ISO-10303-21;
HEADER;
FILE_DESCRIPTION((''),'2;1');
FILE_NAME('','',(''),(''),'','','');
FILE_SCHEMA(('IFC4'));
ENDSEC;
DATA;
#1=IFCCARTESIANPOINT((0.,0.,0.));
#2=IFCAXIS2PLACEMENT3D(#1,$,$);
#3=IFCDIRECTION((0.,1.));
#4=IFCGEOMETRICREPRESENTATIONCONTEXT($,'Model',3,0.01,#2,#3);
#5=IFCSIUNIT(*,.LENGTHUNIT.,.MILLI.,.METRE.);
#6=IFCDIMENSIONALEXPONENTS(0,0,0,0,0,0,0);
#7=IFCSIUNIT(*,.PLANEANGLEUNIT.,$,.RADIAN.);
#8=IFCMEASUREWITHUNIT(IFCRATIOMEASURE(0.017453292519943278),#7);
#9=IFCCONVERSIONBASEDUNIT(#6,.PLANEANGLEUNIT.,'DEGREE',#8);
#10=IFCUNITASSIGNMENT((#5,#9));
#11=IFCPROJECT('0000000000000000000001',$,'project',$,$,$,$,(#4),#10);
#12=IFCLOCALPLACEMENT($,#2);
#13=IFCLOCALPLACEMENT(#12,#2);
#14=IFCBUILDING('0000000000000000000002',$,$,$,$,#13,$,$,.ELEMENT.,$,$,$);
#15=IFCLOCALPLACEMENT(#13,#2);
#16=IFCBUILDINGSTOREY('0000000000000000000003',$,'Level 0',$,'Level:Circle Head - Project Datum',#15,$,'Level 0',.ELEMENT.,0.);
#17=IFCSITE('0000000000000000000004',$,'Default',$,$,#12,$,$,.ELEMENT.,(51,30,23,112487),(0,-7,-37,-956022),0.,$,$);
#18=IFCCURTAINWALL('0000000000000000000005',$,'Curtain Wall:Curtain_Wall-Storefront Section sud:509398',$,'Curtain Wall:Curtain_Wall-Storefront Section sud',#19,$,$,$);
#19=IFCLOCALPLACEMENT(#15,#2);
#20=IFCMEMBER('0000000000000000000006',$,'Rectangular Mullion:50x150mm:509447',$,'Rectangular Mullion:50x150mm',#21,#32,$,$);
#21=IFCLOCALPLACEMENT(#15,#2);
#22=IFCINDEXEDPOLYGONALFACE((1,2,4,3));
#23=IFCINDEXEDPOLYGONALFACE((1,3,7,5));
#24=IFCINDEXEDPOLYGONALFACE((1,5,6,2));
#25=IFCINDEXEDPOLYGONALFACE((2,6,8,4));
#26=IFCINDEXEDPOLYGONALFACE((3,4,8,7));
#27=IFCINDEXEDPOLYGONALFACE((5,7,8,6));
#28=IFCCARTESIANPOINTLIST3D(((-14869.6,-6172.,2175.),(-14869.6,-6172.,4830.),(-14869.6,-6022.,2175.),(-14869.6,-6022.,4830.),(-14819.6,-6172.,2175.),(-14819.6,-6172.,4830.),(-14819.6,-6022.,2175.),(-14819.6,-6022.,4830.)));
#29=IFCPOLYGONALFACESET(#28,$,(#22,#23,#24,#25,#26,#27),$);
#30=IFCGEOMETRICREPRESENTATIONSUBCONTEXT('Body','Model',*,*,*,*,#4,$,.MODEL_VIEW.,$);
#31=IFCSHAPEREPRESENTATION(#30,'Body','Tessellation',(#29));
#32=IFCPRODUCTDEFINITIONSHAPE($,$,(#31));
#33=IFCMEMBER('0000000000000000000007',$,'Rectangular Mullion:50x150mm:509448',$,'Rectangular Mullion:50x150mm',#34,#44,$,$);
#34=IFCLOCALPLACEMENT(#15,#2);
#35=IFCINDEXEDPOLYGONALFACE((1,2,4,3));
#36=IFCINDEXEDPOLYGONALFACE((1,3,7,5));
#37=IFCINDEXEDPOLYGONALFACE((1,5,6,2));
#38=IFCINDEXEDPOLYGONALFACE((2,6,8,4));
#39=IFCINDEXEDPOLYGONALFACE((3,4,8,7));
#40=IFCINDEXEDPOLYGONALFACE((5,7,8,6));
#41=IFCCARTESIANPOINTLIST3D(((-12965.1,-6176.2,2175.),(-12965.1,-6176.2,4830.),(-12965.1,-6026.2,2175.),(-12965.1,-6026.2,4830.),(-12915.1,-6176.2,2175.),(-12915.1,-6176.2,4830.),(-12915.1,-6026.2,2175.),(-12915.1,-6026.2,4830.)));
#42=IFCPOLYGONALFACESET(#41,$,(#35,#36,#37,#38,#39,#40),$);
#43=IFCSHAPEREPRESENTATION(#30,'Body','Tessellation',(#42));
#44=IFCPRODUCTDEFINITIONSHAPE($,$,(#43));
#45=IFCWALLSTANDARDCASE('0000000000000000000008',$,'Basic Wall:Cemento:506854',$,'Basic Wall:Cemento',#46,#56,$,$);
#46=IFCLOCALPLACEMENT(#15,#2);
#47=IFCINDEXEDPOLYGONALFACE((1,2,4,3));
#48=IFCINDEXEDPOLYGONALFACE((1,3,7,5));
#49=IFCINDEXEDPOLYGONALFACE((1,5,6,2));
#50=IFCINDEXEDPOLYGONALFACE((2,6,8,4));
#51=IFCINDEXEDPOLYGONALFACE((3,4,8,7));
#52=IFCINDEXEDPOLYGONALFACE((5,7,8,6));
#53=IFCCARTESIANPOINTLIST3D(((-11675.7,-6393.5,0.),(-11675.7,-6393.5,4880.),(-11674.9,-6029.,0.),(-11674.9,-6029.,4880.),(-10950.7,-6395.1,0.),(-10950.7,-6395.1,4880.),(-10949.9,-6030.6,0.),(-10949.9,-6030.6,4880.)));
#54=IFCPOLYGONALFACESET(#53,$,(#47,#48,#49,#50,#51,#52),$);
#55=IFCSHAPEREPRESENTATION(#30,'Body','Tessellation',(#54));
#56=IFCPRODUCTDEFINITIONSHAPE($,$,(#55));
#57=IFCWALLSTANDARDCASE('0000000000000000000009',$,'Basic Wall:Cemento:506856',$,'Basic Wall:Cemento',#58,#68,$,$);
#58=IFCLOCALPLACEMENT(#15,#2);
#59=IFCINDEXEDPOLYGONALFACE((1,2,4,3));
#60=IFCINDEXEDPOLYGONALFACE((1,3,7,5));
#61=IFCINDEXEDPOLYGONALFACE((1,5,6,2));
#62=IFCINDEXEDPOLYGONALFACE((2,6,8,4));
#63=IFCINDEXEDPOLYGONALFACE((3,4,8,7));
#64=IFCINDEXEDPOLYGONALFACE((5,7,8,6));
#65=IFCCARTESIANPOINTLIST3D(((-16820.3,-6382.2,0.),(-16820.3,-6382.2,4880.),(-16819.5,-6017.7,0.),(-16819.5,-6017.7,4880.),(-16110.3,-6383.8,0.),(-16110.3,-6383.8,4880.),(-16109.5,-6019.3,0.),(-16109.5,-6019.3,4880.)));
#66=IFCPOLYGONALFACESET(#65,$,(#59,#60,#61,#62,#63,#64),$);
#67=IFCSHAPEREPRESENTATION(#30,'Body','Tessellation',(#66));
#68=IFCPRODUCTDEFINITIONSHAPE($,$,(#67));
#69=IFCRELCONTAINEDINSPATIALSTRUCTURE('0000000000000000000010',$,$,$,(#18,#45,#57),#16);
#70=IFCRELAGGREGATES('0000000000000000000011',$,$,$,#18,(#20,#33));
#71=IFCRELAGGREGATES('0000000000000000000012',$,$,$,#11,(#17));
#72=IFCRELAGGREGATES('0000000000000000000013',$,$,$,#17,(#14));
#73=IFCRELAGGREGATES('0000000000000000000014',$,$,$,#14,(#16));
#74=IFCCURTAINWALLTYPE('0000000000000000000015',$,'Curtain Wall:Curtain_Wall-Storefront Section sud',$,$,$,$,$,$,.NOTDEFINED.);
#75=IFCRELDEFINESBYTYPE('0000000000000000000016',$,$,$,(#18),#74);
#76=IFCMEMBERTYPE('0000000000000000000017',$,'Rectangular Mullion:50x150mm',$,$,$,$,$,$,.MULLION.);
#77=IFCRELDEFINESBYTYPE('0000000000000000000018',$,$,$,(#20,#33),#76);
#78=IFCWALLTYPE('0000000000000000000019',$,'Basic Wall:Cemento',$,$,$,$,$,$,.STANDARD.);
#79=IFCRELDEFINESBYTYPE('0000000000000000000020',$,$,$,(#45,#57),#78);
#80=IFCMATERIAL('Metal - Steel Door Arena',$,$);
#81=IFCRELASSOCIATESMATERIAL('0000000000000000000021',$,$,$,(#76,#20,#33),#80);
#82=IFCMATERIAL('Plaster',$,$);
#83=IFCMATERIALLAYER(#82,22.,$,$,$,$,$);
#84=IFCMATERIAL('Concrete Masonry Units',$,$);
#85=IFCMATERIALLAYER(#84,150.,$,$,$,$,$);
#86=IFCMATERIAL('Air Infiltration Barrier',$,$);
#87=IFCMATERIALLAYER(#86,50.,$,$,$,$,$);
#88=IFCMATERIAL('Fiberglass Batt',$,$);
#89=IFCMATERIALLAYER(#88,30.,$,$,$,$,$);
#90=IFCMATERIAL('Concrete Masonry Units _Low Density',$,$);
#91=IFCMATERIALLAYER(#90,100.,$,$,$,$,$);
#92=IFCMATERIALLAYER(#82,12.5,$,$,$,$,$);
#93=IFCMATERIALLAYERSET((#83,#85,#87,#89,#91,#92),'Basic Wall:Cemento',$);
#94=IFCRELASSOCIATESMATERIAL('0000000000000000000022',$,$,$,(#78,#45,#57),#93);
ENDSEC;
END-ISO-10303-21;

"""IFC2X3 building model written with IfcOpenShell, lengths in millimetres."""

from ifc_helpers import new_model, entity, si_unit, converted_unit, direction, frame, frame_2d, origin, origin_2d_with_axis, place, context, subcontext, project, spatial, rectangle, extrude, source, transform, mapped, material, layer, layer_set, layer_usage, type_object, type_shapes, element, aggregate, save


model = new_model("IFC2X3")

# Units and contexts
model_context = context("Model", 3, precision=0.01, world=origin(), true_north=direction((0.0, 1.0)))
body_context = subcontext(model_context, "Body", "Model", "MODEL_VIEW")
ifc_project = project(units=[si_unit("LENGTHUNIT", "METRE", prefix="MILLI"), converted_unit("PLANEANGLEUNIT", "DEGREE", entity("IfcRatioMeasure", 0.017453292519943278), si_unit("PLANEANGLEUNIT", "RADIAN"), dimensions=[0, 0, 0, 0, 0, 0, 0])], contexts=[model_context])

# Site, building, storey
site_placement = place(None, origin())
site = spatial("IfcSite", under=ifc_project, at=site_placement, Name="Default", CompositionType="ELEMENT", RefLatitude=(51, 30, 23, 112487), RefLongitude=(0, -7, -37, -956022), RefElevation=0.0)
building_placement = place(site_placement, origin())
building = spatial("IfcBuilding", under=site, at=building_placement, CompositionType="ELEMENT")
storey_placement = place(building_placement, origin())
storey = spatial("IfcBuildingStorey", under=building, at=storey_placement, Name="Level 0", ObjectType="Level:Circle Head - Project Datum", LongName="Level 0", CompositionType="ELEMENT", Elevation=0.0)

# Curtain wall, members
curtain_wall_type = type_object("IfcCurtainWallType", Name="Curtain Wall:Curtain_Wall-Storefront Section sud", PredefinedType="NOTDEFINED")
curtain_wall_placement = place(storey_placement, origin())
curtain_wall = element("IfcCurtainWall", 1, at=curtain_wall_placement, inside=storey, type_object=curtain_wall_type, Name="Curtain Wall:Curtain_Wall-Storefront Section sud:509398", ObjectType="Curtain Wall:Curtain_Wall-Storefront Section sud")
ifc_material_1 = material(Name="Metal - Steel Door Arena")
member_type_1 = type_object("IfcMemberType", Name="Rectangular Mullion:50x150mm", PredefinedType="MULLION", material=ifc_material_1)
shared_shape_1 = source(origin(), body_context, "Body", "SweptSolid", [
    extrude(rectangle(XDim=150.0, YDim=50.0, at=origin_2d_with_axis()), frame((0.0, 0.0, -2655.0), z_axis=(0.0, 0.0, 1.0), x_axis=(0.0, -1.0, 0.0)), (0.0, 0.0, 1.0), 2655.0),
])
type_shapes(member_type_1, [shared_shape_1])
member_1_placement = place(curtain_wall_placement, frame((-14844.6, -6097.0, 2175.0), z_axis=(0.0, 0.0, -1.0), x_axis=(1.0, 0.0, 0.0)))
member_1 = element("IfcMember", 2, at=member_1_placement, type_object=member_type_1, material=ifc_material_1, Name="Rectangular Mullion:50x150mm:509447", ObjectType="Rectangular Mullion:50x150mm", context=body_context, shape_type="MappedRepresentation", body=[
    mapped(shared_shape_1, transform((0.0, 0.0, 0.0), scale=1.0)),
])
member_2_placement = place(curtain_wall_placement, frame((-12940.1, -6101.2, 2175.0), z_axis=(0.0, 0.0, -1.0), x_axis=(1.0, 0.0, 0.0)))
member_2 = element("IfcMember", 3, at=member_2_placement, type_object=member_type_1, material=ifc_material_1, Name="Rectangular Mullion:50x150mm:509448", ObjectType="Rectangular Mullion:50x150mm", context=body_context, shape_type="MappedRepresentation", body=[
    mapped(shared_shape_1, transform((0.0, 0.0, 0.0), scale=1.0)),
])
aggregate(curtain_wall, [member_1, member_2])

# Walls
ifc_material_2 = material(Name="Plaster")
ifc_layer_1 = layer(ifc_material_2, 22.0)
ifc_material_3 = material(Name="Concrete Masonry Units")
ifc_layer_2 = layer(ifc_material_3, 150.0)
ifc_material_4 = material(Name="Air Infiltration Barrier")
ifc_layer_3 = layer(ifc_material_4, 50.0)
ifc_material_5 = material(Name="Fiberglass Batt")
ifc_layer_4 = layer(ifc_material_5, 30.0)
ifc_material_6 = material(Name="Concrete Masonry Units _Low Density")
ifc_layer_5 = layer(ifc_material_6, 100.0)
ifc_layer_6 = layer(ifc_material_2, 12.5)
ifc_layer_set_1 = layer_set([ifc_layer_1, ifc_layer_2, ifc_layer_3, ifc_layer_4, ifc_layer_5, ifc_layer_6], Name="Basic Wall:Cemento")
ifc_layer_usage_1 = layer_usage(ifc_layer_set_1, "AXIS2", "NEGATIVE", 182.3)
wall_type_1 = type_object("IfcWallType", Name="Basic Wall:Cemento", PredefinedType="STANDARD", material=ifc_layer_set_1)
wall_1_placement = place(storey_placement, frame((-10950.3, -6212.9, 0.0), z_axis=(0.0, 0.0, 1.0), x_axis=(-0.999998, 0.002199, 0.0)))
element("IfcWallStandardCase", 4, at=wall_1_placement, inside=storey, type_object=wall_type_1, material=ifc_layer_usage_1, Name="Basic Wall:Cemento:506854", ObjectType="Basic Wall:Cemento", context=body_context, shape_type="SweptSolid", body=[
    extrude(rectangle(XDim=725.0, YDim=364.5, at=frame_2d((362.5, 0.0), x_axis=(-1.0, 0.0))), origin(), (0.0, 0.0, 1.0), 4880.0),
])
ifc_layer_usage_2 = layer_usage(ifc_layer_set_1, "AXIS2", "NEGATIVE", 182.3)
wall_2_placement = place(storey_placement, frame((-16109.9, -6201.5, 0.0), z_axis=(0.0, 0.0, 1.0), x_axis=(-0.999998, 0.002199, 0.0)))
element("IfcWallStandardCase", 5, at=wall_2_placement, inside=storey, type_object=wall_type_1, material=ifc_layer_usage_2, Name="Basic Wall:Cemento:506856", ObjectType="Basic Wall:Cemento", context=body_context, shape_type="SweptSolid", body=[
    extrude(rectangle(XDim=710.0, YDim=364.5, at=frame_2d((355.0, 0.0), x_axis=(-1.0, 0.0))), origin(), (0.0, 0.0, 1.0), 4880.0),
])

save(model, "model.ifc")
